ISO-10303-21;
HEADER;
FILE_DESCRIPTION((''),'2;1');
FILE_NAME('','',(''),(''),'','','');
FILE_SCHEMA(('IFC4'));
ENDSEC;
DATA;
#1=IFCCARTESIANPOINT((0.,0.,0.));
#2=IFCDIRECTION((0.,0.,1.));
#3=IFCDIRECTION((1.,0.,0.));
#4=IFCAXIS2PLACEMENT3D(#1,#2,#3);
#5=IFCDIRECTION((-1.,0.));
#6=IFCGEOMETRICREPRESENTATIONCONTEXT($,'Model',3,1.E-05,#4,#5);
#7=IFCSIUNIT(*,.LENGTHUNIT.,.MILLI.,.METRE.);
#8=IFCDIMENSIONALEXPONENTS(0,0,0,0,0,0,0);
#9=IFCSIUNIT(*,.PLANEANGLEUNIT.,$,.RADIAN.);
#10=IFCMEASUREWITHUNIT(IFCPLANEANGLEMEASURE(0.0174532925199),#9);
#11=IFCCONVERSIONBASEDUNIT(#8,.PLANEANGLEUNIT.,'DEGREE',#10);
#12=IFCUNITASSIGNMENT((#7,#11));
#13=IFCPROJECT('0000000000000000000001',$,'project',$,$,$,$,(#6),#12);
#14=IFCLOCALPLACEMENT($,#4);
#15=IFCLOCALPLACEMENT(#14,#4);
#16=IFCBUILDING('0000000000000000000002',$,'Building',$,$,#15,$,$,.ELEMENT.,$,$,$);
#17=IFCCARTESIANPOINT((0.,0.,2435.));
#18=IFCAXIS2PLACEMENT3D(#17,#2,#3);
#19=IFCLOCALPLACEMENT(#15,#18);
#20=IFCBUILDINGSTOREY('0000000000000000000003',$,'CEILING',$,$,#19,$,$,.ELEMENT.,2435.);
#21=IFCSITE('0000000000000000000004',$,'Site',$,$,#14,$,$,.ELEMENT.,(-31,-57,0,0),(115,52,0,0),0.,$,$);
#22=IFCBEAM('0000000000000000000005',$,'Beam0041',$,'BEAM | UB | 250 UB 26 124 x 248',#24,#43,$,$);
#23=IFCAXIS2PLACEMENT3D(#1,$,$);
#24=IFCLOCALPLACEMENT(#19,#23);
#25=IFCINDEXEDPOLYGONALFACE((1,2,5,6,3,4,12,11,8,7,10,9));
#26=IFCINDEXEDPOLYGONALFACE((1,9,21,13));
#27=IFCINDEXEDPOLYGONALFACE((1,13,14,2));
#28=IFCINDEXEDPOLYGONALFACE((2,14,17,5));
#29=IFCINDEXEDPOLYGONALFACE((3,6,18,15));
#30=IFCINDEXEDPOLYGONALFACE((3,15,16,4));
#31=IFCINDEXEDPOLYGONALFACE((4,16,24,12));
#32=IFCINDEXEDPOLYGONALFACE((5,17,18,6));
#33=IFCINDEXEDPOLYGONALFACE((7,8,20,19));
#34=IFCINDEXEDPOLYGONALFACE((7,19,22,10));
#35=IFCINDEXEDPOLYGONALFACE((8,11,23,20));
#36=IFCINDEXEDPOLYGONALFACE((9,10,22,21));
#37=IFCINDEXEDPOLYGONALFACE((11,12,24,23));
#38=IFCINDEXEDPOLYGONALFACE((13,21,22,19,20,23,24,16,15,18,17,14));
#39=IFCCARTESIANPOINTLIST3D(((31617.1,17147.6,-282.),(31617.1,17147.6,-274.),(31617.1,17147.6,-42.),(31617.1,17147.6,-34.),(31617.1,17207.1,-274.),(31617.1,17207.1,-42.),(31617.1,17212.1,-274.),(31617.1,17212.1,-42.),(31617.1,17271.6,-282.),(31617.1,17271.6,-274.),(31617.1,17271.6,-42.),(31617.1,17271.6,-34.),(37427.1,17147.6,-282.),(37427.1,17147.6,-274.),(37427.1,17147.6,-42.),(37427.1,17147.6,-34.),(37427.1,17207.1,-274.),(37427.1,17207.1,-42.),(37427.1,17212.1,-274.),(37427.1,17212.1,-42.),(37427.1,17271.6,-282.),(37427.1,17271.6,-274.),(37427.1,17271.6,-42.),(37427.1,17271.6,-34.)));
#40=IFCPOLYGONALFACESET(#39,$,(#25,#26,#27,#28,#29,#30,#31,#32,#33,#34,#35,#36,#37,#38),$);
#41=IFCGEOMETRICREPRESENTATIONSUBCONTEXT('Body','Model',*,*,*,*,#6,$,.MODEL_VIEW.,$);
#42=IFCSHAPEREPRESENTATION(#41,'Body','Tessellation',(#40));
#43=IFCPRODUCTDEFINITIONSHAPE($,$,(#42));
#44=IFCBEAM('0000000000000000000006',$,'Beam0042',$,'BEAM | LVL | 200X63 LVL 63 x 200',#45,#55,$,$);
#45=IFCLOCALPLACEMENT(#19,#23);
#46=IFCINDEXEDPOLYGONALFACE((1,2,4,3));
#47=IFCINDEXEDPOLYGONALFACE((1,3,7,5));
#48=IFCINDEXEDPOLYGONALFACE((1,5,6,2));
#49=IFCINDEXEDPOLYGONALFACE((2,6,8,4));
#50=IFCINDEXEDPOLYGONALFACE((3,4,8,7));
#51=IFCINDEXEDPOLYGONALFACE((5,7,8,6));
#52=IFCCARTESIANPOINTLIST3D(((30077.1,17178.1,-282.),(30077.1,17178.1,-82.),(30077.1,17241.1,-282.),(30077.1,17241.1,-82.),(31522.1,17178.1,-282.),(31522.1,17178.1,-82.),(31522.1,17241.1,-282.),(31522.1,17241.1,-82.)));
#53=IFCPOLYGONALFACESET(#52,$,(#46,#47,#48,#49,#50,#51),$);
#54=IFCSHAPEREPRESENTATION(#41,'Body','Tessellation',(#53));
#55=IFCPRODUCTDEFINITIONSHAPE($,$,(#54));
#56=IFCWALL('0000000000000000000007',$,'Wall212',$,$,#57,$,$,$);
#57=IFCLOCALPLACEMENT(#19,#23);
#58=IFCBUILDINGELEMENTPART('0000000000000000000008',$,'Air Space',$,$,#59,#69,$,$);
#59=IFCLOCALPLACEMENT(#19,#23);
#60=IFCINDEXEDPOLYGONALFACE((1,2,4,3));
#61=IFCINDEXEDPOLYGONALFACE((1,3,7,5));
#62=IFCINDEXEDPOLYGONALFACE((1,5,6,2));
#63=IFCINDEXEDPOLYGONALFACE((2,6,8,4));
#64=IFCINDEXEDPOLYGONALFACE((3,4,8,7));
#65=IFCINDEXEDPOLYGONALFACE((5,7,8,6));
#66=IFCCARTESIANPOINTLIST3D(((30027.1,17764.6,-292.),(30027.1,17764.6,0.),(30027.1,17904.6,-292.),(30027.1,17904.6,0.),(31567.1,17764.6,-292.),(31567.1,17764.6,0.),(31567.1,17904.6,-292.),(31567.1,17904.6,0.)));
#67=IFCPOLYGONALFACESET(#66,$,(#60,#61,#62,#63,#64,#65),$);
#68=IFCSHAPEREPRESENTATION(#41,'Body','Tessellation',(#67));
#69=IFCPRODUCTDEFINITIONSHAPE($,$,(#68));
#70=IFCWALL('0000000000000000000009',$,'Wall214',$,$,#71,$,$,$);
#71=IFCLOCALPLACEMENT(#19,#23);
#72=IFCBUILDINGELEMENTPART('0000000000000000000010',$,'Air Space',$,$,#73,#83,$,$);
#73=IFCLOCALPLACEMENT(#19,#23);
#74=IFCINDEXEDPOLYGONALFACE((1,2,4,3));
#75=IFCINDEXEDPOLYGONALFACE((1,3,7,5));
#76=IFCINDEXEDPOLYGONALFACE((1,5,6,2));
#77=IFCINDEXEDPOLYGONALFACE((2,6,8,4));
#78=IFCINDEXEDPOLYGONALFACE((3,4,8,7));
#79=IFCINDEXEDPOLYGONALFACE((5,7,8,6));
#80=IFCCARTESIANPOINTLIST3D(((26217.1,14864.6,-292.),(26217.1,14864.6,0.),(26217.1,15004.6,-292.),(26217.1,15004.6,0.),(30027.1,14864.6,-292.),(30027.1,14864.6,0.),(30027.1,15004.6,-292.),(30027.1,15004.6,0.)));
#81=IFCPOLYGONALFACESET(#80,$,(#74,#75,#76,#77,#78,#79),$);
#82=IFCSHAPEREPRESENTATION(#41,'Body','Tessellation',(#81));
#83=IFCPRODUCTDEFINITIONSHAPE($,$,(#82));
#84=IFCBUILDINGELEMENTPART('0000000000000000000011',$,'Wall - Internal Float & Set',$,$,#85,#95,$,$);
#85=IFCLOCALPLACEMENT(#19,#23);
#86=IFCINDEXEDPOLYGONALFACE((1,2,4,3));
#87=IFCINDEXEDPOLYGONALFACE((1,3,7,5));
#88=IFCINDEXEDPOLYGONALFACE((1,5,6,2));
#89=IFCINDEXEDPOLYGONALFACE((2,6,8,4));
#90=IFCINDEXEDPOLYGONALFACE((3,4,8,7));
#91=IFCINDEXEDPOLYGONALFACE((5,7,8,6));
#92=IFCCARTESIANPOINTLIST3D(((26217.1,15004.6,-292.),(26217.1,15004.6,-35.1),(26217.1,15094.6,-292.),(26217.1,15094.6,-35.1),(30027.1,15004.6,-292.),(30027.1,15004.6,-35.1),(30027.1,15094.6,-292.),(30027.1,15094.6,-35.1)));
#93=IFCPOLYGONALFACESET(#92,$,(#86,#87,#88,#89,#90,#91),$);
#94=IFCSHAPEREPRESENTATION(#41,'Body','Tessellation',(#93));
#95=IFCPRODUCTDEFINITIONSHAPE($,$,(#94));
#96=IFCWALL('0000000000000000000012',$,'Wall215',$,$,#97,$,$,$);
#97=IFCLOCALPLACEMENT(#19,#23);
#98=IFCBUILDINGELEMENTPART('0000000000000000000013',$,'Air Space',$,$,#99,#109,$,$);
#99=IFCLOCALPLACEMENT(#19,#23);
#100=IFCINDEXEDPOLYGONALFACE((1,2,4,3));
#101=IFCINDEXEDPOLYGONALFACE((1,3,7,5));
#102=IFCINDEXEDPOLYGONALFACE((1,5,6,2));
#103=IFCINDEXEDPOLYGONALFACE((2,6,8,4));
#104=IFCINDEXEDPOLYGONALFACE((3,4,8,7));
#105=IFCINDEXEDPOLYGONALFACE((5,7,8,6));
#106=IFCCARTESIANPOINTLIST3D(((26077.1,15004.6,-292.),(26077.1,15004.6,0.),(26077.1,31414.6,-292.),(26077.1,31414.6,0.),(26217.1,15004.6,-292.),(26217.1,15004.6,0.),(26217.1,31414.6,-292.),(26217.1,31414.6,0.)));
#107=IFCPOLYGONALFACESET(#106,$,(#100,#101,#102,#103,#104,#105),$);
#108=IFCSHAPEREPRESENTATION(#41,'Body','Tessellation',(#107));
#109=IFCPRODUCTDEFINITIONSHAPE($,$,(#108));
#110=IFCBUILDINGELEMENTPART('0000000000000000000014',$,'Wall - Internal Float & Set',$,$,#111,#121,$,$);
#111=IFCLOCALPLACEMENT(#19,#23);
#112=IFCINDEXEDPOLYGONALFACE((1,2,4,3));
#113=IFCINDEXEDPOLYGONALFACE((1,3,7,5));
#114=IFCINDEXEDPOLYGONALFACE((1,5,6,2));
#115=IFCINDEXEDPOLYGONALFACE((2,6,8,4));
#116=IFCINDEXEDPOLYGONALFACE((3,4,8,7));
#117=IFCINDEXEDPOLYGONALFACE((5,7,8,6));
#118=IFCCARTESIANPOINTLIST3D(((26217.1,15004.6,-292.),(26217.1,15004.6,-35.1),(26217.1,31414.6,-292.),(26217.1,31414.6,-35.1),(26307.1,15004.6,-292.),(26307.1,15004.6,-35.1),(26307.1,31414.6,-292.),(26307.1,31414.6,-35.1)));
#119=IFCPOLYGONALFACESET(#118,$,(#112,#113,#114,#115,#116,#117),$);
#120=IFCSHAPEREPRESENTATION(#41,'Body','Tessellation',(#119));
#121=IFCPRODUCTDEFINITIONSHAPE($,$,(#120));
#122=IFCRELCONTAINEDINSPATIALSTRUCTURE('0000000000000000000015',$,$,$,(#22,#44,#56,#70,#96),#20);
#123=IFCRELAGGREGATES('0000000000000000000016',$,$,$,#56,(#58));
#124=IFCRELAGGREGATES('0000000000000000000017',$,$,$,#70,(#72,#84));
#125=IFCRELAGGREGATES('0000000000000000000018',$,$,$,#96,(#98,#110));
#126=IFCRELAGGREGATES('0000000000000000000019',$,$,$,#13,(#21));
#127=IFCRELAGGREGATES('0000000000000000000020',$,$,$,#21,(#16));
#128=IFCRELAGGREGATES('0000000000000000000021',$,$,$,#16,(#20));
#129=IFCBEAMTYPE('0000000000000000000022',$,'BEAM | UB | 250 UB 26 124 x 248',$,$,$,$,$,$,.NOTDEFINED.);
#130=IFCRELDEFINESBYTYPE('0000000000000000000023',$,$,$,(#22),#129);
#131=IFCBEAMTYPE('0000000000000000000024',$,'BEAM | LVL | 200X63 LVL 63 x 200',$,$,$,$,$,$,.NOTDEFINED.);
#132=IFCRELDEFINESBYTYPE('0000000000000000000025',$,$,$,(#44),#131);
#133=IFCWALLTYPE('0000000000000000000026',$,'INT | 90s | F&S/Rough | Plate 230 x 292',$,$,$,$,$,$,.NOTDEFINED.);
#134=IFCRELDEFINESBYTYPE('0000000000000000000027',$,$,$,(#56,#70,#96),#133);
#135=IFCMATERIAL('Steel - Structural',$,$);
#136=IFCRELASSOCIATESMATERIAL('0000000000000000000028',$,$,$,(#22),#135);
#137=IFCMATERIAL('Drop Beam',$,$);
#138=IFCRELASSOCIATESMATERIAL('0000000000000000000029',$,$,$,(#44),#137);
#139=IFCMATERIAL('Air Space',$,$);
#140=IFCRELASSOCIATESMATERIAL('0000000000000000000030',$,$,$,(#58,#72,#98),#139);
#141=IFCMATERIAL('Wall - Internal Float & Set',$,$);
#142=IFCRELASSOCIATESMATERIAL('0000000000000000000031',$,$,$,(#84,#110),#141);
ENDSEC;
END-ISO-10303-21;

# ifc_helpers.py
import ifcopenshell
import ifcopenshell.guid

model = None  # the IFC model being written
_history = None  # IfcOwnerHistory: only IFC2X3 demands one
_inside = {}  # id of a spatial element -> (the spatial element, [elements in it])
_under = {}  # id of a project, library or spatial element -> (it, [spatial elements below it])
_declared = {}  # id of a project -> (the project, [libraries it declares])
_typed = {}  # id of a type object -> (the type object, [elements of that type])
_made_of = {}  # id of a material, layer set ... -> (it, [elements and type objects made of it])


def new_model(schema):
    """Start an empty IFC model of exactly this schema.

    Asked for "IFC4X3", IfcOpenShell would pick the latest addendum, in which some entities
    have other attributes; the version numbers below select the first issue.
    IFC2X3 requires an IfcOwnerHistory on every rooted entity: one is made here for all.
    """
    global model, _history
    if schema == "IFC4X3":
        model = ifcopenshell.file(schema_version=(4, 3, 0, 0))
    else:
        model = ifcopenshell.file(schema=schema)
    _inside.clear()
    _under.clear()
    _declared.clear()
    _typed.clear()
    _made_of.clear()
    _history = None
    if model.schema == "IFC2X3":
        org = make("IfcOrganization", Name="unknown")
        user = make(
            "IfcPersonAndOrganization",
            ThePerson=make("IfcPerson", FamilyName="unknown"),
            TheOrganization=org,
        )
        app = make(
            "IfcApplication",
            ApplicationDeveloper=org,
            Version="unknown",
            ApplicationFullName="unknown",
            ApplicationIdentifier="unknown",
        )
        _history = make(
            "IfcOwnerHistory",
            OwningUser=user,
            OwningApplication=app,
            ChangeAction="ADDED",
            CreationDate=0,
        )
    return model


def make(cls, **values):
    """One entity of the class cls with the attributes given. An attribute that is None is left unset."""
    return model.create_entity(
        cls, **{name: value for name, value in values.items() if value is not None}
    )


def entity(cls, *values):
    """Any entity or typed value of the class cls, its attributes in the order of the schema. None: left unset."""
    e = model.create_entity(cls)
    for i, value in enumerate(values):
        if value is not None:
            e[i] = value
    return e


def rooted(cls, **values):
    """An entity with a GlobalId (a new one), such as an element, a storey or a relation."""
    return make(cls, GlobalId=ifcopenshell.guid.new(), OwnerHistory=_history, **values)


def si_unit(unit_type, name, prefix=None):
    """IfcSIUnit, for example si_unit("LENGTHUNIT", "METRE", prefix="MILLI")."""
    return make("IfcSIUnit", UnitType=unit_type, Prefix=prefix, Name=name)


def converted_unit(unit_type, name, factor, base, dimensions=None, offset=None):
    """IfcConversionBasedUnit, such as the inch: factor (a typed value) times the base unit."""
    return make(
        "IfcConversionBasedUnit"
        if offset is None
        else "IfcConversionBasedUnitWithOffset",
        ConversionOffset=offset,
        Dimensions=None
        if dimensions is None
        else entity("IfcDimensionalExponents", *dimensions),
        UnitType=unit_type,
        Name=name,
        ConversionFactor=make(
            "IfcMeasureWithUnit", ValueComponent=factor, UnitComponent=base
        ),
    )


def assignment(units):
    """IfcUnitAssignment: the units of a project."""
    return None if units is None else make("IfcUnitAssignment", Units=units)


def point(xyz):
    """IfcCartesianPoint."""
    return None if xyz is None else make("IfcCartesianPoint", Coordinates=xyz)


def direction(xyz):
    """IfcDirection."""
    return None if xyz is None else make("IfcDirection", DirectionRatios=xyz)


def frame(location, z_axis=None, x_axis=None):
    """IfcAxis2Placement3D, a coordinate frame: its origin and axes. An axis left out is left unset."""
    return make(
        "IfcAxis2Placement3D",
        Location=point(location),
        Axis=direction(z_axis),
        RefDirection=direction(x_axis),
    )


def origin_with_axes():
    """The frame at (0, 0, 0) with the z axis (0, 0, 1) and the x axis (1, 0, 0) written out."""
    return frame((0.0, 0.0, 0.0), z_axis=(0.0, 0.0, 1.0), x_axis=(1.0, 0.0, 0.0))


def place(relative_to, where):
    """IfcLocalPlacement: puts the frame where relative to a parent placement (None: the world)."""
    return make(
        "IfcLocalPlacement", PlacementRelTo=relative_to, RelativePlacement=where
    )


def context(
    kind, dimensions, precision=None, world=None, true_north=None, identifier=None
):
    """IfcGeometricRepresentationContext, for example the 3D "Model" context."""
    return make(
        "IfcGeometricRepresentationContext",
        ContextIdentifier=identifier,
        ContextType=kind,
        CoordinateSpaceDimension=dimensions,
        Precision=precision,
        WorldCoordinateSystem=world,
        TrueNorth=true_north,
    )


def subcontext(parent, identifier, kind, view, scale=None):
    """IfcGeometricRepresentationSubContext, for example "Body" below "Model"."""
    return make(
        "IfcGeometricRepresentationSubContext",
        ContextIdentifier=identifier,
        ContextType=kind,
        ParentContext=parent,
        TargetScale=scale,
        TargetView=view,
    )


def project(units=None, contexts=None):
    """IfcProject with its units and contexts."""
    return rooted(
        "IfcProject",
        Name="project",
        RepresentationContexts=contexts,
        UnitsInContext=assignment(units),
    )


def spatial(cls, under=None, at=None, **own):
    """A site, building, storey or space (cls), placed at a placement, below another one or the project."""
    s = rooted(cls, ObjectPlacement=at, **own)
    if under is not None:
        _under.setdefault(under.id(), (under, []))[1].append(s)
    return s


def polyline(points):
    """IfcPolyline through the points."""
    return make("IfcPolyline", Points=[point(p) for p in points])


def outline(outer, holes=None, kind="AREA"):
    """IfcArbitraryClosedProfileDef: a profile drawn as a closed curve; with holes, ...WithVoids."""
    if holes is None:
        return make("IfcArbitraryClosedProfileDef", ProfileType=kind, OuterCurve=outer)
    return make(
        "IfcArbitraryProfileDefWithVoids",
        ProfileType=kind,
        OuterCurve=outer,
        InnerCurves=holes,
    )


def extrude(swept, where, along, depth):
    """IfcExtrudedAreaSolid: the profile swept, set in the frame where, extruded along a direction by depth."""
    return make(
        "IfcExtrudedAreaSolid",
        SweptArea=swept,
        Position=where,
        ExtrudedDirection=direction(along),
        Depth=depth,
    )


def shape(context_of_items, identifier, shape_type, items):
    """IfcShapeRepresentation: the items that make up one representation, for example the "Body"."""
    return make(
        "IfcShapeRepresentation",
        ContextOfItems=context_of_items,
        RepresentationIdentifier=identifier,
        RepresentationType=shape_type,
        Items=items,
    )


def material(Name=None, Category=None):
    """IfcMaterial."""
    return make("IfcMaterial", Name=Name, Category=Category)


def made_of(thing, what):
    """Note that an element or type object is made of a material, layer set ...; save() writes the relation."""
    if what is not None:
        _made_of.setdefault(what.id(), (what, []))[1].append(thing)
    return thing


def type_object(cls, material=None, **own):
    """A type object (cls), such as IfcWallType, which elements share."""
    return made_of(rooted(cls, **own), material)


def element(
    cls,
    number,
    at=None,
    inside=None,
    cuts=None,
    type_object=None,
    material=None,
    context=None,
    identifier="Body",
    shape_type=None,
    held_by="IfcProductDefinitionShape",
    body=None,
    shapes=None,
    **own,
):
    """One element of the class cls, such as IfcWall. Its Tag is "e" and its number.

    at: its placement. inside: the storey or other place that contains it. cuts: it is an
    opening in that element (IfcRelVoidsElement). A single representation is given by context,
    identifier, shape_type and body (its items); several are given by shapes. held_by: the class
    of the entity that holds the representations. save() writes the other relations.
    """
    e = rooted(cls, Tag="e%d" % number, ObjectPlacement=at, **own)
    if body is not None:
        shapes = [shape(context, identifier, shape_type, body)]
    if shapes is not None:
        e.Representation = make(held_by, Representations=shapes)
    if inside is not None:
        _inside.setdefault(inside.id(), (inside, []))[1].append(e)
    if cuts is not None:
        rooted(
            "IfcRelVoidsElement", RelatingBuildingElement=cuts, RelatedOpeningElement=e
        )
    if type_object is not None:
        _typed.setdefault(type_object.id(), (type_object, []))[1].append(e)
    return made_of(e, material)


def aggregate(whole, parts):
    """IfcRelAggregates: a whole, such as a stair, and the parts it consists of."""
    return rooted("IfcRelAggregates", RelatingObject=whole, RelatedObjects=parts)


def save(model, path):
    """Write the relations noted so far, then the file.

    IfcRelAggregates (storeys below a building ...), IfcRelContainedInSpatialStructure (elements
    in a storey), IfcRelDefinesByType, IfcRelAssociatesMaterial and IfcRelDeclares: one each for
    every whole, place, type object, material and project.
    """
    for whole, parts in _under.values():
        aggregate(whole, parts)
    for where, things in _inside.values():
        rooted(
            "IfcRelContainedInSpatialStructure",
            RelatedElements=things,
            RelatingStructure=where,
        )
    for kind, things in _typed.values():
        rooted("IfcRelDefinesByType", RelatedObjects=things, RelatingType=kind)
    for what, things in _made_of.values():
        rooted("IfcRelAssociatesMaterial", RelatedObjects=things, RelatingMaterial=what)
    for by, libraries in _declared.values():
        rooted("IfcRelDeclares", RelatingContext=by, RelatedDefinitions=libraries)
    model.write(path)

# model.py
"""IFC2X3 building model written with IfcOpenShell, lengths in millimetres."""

from ifc_helpers import new_model, entity, si_unit, converted_unit, direction, frame, origin_with_axes, place, context, subcontext, project, spatial, polyline, outline, extrude, material, type_object, element, aggregate, save


model = new_model("IFC2X3")

# Units and contexts
model_context = context("Model", 3, precision=1e-05, world=origin_with_axes(), true_north=direction((-1.0, 0.0)))
body_context = subcontext(model_context, "Body", "Model", "MODEL_VIEW")
ifc_project = project(units=[si_unit("LENGTHUNIT", "METRE", prefix="MILLI"), converted_unit("PLANEANGLEUNIT", "DEGREE", entity("IfcPlaneAngleMeasure", 0.0174532925199), si_unit("PLANEANGLEUNIT", "RADIAN"), dimensions=[0, 0, 0, 0, 0, 0, 0])], contexts=[model_context])

# Site, building, storey
site_placement = place(None, origin_with_axes())
site = spatial("IfcSite", under=ifc_project, at=site_placement, Name="Site", CompositionType="ELEMENT", RefLatitude=(-31, -57, 0, 0), RefLongitude=(115, 52, 0, 0), RefElevation=0.0)
building_placement = place(site_placement, origin_with_axes())
building = spatial("IfcBuilding", under=site, at=building_placement, Name="Building", CompositionType="ELEMENT")
storey_placement = place(building_placement, frame((0.0, 0.0, 2435.0), z_axis=(0.0, 0.0, 1.0), x_axis=(1.0, 0.0, 0.0)))
storey = spatial("IfcBuildingStorey", under=building, at=storey_placement, Name="CEILING", CompositionType="ELEMENT", Elevation=2435.0)

# Beams
ifc_material_1 = material(Name="Steel - Structural")
beam_type_1 = type_object("IfcBeamType", Name="BEAM | UB | 250 UB 26 124 x 248", PredefinedType="NOTDEFINED")
beam_1_placement = place(storey_placement, frame((37427.1, 17209.6, -282.0), z_axis=(0.0, 0.0, 1.0), x_axis=(0.0, 1.0, 0.0)))
element("IfcBeam", 1, at=beam_1_placement, inside=storey, type_object=beam_type_1, material=ifc_material_1, Name="Beam0041", ObjectType="BEAM | UB | 250 UB 26 124 x 248", context=body_context, shape_type="SweptSolid", body=[
    extrude(outline(polyline([(-62.0, 248.0), (-62.0, 240.0), (-2.5, 240.0), (-2.5, 8.0), (-62.0, 8.0), (-62.0, 0.0), (62.0, 0.0), (62.0, 8.0), (2.5, 8.0), (2.5, 240.0), (62.0, 240.0), (62.0, 248.0), (-62.0, 248.0)])), frame((0.0, 5810.0, 0.0), z_axis=(0.0, -1.0, 0.0), x_axis=(1.0, 0.0, 0.0)), (0.0, 0.0, 1.0), 5810.0),
])
ifc_material_2 = material(Name="Drop Beam")
beam_type_2 = type_object("IfcBeamType", Name="BEAM | LVL | 200X63 LVL 63 x 200", PredefinedType="NOTDEFINED")
beam_2_placement = place(storey_placement, frame((31522.1, 17209.6, -282.0), z_axis=(0.0, 0.0, 1.0), x_axis=(0.0, 1.0, 0.0)))
element("IfcBeam", 2, at=beam_2_placement, inside=storey, type_object=beam_type_2, material=ifc_material_2, Name="Beam0042", ObjectType="BEAM | LVL | 200X63 LVL 63 x 200", context=body_context, shape_type="SweptSolid", body=[
    extrude(outline(polyline([(-31.5, 200.0), (-31.5, 0.0), (31.5, 0.0), (31.5, 200.0), (-31.5, 200.0)])), frame((0.0, 1445.0, 0.0), z_axis=(0.0, -1.0, 0.0), x_axis=(1.0, 0.0, 0.0)), (0.0, 0.0, 1.0), 1445.0),
])

# Shared definitions
ifc_material_3 = material(Name="Air Space")

# Walls, building element parts
wall_type = type_object("IfcWallType", Name="INT | 90s | F&S/Rough | Plate 230 x 292", PredefinedType="NOTDEFINED")
wall_1_placement = place(storey_placement, frame((31567.1, 17904.6, -292.0), z_axis=(0.0, 0.0, 1.0), x_axis=(-1.0, 0.0, 0.0)))
wall_1 = element("IfcWall", 3, at=wall_1_placement, inside=storey, type_object=wall_type, Name="Wall212")
building_element_part_1_placement = place(wall_1_placement, origin_with_axes())
building_element_part_1 = element("IfcBuildingElementPart", 4, at=building_element_part_1_placement, material=ifc_material_3, Name="Air Space", context=body_context, shape_type="SweptSolid", body=[
    extrude(outline(polyline([(0.0, 292.0), (0.0, 0.0), (140.0, 0.0), (140.0, 292.0), (0.0, 292.0)])), frame((0.0, 0.0, 0.0), z_axis=(1.0, 0.0, 0.0), x_axis=(0.0, 1.0, 0.0)), (0.0, 0.0, 1.0), 1540.0),
])
aggregate(wall_1, [building_element_part_1])
wall_2_placement = place(storey_placement, frame((30027.1, 15004.6, -292.0), z_axis=(0.0, 0.0, 1.0), x_axis=(-1.0, 0.0, 0.0)))
wall_2 = element("IfcWall", 5, at=wall_2_placement, inside=storey, type_object=wall_type, Name="Wall214")
building_element_part_2_placement = place(wall_2_placement, origin_with_axes())
building_element_part_2 = element("IfcBuildingElementPart", 6, at=building_element_part_2_placement, material=ifc_material_3, Name="Air Space", context=body_context, shape_type="SweptSolid", body=[
    extrude(outline(polyline([(0.0, 292.0), (0.0, 0.0), (140.0, 0.0), (140.0, 292.0), (0.0, 292.0)])), frame((0.0, 0.0, 0.0), z_axis=(1.0, 0.0, 0.0), x_axis=(0.0, 1.0, 0.0)), (0.0, 0.0, 1.0), 3810.0),
])
ifc_material_4 = material(Name="Wall - Internal Float & Set")
building_element_part_3_placement = place(wall_2_placement, origin_with_axes())
building_element_part_3 = element("IfcBuildingElementPart", 7, at=building_element_part_3_placement, material=ifc_material_4, Name="Wall - Internal Float & Set", context=body_context, shape_type="SweptSolid", body=[
    extrude(outline(polyline([(-90.0, 256.9), (-90.0, 0.0), (0.0, 0.0), (0.0, 256.9), (-90.0, 256.9)])), frame((0.0, 0.0, 0.0), z_axis=(1.0, 0.0, 0.0), x_axis=(0.0, 1.0, 0.0)), (0.0, 0.0, 1.0), 3810.0),
])
aggregate(wall_2, [building_element_part_2, building_element_part_3])
wall_3_placement = place(storey_placement, frame((26217.1, 15004.6, -292.0), z_axis=(0.0, 0.0, 1.0), x_axis=(0.0, 1.0, 0.0)))
wall_3 = element("IfcWall", 8, at=wall_3_placement, inside=storey, type_object=wall_type, Name="Wall215")
building_element_part_4_placement = place(wall_3_placement, origin_with_axes())
building_element_part_4 = element("IfcBuildingElementPart", 9, at=building_element_part_4_placement, material=ifc_material_3, Name="Air Space", context=body_context, shape_type="SweptSolid", body=[
    extrude(outline(polyline([(0.0, 292.0), (0.0, 0.0), (140.0, 0.0), (140.0, 292.0), (0.0, 292.0)])), frame((0.0, 0.0, 0.0), z_axis=(1.0, 0.0, 0.0), x_axis=(0.0, 1.0, 0.0)), (0.0, 0.0, 1.0), 16410.0),
])
building_element_part_5_placement = place(wall_3_placement, origin_with_axes())
building_element_part_5 = element("IfcBuildingElementPart", 10, at=building_element_part_5_placement, material=ifc_material_4, Name="Wall - Internal Float & Set", context=body_context, shape_type="SweptSolid", body=[
    extrude(outline(polyline([(-90.0, 256.9), (-90.0, 0.0), (0.0, 0.0), (0.0, 256.9), (-90.0, 256.9)])), frame((0.0, 0.0, 0.0), z_axis=(1.0, 0.0, 0.0), x_axis=(0.0, 1.0, 0.0)), (0.0, 0.0, 1.0), 16410.0),
])
aggregate(wall_3, [building_element_part_4, building_element_part_5])

save(model, "model.ifc")
